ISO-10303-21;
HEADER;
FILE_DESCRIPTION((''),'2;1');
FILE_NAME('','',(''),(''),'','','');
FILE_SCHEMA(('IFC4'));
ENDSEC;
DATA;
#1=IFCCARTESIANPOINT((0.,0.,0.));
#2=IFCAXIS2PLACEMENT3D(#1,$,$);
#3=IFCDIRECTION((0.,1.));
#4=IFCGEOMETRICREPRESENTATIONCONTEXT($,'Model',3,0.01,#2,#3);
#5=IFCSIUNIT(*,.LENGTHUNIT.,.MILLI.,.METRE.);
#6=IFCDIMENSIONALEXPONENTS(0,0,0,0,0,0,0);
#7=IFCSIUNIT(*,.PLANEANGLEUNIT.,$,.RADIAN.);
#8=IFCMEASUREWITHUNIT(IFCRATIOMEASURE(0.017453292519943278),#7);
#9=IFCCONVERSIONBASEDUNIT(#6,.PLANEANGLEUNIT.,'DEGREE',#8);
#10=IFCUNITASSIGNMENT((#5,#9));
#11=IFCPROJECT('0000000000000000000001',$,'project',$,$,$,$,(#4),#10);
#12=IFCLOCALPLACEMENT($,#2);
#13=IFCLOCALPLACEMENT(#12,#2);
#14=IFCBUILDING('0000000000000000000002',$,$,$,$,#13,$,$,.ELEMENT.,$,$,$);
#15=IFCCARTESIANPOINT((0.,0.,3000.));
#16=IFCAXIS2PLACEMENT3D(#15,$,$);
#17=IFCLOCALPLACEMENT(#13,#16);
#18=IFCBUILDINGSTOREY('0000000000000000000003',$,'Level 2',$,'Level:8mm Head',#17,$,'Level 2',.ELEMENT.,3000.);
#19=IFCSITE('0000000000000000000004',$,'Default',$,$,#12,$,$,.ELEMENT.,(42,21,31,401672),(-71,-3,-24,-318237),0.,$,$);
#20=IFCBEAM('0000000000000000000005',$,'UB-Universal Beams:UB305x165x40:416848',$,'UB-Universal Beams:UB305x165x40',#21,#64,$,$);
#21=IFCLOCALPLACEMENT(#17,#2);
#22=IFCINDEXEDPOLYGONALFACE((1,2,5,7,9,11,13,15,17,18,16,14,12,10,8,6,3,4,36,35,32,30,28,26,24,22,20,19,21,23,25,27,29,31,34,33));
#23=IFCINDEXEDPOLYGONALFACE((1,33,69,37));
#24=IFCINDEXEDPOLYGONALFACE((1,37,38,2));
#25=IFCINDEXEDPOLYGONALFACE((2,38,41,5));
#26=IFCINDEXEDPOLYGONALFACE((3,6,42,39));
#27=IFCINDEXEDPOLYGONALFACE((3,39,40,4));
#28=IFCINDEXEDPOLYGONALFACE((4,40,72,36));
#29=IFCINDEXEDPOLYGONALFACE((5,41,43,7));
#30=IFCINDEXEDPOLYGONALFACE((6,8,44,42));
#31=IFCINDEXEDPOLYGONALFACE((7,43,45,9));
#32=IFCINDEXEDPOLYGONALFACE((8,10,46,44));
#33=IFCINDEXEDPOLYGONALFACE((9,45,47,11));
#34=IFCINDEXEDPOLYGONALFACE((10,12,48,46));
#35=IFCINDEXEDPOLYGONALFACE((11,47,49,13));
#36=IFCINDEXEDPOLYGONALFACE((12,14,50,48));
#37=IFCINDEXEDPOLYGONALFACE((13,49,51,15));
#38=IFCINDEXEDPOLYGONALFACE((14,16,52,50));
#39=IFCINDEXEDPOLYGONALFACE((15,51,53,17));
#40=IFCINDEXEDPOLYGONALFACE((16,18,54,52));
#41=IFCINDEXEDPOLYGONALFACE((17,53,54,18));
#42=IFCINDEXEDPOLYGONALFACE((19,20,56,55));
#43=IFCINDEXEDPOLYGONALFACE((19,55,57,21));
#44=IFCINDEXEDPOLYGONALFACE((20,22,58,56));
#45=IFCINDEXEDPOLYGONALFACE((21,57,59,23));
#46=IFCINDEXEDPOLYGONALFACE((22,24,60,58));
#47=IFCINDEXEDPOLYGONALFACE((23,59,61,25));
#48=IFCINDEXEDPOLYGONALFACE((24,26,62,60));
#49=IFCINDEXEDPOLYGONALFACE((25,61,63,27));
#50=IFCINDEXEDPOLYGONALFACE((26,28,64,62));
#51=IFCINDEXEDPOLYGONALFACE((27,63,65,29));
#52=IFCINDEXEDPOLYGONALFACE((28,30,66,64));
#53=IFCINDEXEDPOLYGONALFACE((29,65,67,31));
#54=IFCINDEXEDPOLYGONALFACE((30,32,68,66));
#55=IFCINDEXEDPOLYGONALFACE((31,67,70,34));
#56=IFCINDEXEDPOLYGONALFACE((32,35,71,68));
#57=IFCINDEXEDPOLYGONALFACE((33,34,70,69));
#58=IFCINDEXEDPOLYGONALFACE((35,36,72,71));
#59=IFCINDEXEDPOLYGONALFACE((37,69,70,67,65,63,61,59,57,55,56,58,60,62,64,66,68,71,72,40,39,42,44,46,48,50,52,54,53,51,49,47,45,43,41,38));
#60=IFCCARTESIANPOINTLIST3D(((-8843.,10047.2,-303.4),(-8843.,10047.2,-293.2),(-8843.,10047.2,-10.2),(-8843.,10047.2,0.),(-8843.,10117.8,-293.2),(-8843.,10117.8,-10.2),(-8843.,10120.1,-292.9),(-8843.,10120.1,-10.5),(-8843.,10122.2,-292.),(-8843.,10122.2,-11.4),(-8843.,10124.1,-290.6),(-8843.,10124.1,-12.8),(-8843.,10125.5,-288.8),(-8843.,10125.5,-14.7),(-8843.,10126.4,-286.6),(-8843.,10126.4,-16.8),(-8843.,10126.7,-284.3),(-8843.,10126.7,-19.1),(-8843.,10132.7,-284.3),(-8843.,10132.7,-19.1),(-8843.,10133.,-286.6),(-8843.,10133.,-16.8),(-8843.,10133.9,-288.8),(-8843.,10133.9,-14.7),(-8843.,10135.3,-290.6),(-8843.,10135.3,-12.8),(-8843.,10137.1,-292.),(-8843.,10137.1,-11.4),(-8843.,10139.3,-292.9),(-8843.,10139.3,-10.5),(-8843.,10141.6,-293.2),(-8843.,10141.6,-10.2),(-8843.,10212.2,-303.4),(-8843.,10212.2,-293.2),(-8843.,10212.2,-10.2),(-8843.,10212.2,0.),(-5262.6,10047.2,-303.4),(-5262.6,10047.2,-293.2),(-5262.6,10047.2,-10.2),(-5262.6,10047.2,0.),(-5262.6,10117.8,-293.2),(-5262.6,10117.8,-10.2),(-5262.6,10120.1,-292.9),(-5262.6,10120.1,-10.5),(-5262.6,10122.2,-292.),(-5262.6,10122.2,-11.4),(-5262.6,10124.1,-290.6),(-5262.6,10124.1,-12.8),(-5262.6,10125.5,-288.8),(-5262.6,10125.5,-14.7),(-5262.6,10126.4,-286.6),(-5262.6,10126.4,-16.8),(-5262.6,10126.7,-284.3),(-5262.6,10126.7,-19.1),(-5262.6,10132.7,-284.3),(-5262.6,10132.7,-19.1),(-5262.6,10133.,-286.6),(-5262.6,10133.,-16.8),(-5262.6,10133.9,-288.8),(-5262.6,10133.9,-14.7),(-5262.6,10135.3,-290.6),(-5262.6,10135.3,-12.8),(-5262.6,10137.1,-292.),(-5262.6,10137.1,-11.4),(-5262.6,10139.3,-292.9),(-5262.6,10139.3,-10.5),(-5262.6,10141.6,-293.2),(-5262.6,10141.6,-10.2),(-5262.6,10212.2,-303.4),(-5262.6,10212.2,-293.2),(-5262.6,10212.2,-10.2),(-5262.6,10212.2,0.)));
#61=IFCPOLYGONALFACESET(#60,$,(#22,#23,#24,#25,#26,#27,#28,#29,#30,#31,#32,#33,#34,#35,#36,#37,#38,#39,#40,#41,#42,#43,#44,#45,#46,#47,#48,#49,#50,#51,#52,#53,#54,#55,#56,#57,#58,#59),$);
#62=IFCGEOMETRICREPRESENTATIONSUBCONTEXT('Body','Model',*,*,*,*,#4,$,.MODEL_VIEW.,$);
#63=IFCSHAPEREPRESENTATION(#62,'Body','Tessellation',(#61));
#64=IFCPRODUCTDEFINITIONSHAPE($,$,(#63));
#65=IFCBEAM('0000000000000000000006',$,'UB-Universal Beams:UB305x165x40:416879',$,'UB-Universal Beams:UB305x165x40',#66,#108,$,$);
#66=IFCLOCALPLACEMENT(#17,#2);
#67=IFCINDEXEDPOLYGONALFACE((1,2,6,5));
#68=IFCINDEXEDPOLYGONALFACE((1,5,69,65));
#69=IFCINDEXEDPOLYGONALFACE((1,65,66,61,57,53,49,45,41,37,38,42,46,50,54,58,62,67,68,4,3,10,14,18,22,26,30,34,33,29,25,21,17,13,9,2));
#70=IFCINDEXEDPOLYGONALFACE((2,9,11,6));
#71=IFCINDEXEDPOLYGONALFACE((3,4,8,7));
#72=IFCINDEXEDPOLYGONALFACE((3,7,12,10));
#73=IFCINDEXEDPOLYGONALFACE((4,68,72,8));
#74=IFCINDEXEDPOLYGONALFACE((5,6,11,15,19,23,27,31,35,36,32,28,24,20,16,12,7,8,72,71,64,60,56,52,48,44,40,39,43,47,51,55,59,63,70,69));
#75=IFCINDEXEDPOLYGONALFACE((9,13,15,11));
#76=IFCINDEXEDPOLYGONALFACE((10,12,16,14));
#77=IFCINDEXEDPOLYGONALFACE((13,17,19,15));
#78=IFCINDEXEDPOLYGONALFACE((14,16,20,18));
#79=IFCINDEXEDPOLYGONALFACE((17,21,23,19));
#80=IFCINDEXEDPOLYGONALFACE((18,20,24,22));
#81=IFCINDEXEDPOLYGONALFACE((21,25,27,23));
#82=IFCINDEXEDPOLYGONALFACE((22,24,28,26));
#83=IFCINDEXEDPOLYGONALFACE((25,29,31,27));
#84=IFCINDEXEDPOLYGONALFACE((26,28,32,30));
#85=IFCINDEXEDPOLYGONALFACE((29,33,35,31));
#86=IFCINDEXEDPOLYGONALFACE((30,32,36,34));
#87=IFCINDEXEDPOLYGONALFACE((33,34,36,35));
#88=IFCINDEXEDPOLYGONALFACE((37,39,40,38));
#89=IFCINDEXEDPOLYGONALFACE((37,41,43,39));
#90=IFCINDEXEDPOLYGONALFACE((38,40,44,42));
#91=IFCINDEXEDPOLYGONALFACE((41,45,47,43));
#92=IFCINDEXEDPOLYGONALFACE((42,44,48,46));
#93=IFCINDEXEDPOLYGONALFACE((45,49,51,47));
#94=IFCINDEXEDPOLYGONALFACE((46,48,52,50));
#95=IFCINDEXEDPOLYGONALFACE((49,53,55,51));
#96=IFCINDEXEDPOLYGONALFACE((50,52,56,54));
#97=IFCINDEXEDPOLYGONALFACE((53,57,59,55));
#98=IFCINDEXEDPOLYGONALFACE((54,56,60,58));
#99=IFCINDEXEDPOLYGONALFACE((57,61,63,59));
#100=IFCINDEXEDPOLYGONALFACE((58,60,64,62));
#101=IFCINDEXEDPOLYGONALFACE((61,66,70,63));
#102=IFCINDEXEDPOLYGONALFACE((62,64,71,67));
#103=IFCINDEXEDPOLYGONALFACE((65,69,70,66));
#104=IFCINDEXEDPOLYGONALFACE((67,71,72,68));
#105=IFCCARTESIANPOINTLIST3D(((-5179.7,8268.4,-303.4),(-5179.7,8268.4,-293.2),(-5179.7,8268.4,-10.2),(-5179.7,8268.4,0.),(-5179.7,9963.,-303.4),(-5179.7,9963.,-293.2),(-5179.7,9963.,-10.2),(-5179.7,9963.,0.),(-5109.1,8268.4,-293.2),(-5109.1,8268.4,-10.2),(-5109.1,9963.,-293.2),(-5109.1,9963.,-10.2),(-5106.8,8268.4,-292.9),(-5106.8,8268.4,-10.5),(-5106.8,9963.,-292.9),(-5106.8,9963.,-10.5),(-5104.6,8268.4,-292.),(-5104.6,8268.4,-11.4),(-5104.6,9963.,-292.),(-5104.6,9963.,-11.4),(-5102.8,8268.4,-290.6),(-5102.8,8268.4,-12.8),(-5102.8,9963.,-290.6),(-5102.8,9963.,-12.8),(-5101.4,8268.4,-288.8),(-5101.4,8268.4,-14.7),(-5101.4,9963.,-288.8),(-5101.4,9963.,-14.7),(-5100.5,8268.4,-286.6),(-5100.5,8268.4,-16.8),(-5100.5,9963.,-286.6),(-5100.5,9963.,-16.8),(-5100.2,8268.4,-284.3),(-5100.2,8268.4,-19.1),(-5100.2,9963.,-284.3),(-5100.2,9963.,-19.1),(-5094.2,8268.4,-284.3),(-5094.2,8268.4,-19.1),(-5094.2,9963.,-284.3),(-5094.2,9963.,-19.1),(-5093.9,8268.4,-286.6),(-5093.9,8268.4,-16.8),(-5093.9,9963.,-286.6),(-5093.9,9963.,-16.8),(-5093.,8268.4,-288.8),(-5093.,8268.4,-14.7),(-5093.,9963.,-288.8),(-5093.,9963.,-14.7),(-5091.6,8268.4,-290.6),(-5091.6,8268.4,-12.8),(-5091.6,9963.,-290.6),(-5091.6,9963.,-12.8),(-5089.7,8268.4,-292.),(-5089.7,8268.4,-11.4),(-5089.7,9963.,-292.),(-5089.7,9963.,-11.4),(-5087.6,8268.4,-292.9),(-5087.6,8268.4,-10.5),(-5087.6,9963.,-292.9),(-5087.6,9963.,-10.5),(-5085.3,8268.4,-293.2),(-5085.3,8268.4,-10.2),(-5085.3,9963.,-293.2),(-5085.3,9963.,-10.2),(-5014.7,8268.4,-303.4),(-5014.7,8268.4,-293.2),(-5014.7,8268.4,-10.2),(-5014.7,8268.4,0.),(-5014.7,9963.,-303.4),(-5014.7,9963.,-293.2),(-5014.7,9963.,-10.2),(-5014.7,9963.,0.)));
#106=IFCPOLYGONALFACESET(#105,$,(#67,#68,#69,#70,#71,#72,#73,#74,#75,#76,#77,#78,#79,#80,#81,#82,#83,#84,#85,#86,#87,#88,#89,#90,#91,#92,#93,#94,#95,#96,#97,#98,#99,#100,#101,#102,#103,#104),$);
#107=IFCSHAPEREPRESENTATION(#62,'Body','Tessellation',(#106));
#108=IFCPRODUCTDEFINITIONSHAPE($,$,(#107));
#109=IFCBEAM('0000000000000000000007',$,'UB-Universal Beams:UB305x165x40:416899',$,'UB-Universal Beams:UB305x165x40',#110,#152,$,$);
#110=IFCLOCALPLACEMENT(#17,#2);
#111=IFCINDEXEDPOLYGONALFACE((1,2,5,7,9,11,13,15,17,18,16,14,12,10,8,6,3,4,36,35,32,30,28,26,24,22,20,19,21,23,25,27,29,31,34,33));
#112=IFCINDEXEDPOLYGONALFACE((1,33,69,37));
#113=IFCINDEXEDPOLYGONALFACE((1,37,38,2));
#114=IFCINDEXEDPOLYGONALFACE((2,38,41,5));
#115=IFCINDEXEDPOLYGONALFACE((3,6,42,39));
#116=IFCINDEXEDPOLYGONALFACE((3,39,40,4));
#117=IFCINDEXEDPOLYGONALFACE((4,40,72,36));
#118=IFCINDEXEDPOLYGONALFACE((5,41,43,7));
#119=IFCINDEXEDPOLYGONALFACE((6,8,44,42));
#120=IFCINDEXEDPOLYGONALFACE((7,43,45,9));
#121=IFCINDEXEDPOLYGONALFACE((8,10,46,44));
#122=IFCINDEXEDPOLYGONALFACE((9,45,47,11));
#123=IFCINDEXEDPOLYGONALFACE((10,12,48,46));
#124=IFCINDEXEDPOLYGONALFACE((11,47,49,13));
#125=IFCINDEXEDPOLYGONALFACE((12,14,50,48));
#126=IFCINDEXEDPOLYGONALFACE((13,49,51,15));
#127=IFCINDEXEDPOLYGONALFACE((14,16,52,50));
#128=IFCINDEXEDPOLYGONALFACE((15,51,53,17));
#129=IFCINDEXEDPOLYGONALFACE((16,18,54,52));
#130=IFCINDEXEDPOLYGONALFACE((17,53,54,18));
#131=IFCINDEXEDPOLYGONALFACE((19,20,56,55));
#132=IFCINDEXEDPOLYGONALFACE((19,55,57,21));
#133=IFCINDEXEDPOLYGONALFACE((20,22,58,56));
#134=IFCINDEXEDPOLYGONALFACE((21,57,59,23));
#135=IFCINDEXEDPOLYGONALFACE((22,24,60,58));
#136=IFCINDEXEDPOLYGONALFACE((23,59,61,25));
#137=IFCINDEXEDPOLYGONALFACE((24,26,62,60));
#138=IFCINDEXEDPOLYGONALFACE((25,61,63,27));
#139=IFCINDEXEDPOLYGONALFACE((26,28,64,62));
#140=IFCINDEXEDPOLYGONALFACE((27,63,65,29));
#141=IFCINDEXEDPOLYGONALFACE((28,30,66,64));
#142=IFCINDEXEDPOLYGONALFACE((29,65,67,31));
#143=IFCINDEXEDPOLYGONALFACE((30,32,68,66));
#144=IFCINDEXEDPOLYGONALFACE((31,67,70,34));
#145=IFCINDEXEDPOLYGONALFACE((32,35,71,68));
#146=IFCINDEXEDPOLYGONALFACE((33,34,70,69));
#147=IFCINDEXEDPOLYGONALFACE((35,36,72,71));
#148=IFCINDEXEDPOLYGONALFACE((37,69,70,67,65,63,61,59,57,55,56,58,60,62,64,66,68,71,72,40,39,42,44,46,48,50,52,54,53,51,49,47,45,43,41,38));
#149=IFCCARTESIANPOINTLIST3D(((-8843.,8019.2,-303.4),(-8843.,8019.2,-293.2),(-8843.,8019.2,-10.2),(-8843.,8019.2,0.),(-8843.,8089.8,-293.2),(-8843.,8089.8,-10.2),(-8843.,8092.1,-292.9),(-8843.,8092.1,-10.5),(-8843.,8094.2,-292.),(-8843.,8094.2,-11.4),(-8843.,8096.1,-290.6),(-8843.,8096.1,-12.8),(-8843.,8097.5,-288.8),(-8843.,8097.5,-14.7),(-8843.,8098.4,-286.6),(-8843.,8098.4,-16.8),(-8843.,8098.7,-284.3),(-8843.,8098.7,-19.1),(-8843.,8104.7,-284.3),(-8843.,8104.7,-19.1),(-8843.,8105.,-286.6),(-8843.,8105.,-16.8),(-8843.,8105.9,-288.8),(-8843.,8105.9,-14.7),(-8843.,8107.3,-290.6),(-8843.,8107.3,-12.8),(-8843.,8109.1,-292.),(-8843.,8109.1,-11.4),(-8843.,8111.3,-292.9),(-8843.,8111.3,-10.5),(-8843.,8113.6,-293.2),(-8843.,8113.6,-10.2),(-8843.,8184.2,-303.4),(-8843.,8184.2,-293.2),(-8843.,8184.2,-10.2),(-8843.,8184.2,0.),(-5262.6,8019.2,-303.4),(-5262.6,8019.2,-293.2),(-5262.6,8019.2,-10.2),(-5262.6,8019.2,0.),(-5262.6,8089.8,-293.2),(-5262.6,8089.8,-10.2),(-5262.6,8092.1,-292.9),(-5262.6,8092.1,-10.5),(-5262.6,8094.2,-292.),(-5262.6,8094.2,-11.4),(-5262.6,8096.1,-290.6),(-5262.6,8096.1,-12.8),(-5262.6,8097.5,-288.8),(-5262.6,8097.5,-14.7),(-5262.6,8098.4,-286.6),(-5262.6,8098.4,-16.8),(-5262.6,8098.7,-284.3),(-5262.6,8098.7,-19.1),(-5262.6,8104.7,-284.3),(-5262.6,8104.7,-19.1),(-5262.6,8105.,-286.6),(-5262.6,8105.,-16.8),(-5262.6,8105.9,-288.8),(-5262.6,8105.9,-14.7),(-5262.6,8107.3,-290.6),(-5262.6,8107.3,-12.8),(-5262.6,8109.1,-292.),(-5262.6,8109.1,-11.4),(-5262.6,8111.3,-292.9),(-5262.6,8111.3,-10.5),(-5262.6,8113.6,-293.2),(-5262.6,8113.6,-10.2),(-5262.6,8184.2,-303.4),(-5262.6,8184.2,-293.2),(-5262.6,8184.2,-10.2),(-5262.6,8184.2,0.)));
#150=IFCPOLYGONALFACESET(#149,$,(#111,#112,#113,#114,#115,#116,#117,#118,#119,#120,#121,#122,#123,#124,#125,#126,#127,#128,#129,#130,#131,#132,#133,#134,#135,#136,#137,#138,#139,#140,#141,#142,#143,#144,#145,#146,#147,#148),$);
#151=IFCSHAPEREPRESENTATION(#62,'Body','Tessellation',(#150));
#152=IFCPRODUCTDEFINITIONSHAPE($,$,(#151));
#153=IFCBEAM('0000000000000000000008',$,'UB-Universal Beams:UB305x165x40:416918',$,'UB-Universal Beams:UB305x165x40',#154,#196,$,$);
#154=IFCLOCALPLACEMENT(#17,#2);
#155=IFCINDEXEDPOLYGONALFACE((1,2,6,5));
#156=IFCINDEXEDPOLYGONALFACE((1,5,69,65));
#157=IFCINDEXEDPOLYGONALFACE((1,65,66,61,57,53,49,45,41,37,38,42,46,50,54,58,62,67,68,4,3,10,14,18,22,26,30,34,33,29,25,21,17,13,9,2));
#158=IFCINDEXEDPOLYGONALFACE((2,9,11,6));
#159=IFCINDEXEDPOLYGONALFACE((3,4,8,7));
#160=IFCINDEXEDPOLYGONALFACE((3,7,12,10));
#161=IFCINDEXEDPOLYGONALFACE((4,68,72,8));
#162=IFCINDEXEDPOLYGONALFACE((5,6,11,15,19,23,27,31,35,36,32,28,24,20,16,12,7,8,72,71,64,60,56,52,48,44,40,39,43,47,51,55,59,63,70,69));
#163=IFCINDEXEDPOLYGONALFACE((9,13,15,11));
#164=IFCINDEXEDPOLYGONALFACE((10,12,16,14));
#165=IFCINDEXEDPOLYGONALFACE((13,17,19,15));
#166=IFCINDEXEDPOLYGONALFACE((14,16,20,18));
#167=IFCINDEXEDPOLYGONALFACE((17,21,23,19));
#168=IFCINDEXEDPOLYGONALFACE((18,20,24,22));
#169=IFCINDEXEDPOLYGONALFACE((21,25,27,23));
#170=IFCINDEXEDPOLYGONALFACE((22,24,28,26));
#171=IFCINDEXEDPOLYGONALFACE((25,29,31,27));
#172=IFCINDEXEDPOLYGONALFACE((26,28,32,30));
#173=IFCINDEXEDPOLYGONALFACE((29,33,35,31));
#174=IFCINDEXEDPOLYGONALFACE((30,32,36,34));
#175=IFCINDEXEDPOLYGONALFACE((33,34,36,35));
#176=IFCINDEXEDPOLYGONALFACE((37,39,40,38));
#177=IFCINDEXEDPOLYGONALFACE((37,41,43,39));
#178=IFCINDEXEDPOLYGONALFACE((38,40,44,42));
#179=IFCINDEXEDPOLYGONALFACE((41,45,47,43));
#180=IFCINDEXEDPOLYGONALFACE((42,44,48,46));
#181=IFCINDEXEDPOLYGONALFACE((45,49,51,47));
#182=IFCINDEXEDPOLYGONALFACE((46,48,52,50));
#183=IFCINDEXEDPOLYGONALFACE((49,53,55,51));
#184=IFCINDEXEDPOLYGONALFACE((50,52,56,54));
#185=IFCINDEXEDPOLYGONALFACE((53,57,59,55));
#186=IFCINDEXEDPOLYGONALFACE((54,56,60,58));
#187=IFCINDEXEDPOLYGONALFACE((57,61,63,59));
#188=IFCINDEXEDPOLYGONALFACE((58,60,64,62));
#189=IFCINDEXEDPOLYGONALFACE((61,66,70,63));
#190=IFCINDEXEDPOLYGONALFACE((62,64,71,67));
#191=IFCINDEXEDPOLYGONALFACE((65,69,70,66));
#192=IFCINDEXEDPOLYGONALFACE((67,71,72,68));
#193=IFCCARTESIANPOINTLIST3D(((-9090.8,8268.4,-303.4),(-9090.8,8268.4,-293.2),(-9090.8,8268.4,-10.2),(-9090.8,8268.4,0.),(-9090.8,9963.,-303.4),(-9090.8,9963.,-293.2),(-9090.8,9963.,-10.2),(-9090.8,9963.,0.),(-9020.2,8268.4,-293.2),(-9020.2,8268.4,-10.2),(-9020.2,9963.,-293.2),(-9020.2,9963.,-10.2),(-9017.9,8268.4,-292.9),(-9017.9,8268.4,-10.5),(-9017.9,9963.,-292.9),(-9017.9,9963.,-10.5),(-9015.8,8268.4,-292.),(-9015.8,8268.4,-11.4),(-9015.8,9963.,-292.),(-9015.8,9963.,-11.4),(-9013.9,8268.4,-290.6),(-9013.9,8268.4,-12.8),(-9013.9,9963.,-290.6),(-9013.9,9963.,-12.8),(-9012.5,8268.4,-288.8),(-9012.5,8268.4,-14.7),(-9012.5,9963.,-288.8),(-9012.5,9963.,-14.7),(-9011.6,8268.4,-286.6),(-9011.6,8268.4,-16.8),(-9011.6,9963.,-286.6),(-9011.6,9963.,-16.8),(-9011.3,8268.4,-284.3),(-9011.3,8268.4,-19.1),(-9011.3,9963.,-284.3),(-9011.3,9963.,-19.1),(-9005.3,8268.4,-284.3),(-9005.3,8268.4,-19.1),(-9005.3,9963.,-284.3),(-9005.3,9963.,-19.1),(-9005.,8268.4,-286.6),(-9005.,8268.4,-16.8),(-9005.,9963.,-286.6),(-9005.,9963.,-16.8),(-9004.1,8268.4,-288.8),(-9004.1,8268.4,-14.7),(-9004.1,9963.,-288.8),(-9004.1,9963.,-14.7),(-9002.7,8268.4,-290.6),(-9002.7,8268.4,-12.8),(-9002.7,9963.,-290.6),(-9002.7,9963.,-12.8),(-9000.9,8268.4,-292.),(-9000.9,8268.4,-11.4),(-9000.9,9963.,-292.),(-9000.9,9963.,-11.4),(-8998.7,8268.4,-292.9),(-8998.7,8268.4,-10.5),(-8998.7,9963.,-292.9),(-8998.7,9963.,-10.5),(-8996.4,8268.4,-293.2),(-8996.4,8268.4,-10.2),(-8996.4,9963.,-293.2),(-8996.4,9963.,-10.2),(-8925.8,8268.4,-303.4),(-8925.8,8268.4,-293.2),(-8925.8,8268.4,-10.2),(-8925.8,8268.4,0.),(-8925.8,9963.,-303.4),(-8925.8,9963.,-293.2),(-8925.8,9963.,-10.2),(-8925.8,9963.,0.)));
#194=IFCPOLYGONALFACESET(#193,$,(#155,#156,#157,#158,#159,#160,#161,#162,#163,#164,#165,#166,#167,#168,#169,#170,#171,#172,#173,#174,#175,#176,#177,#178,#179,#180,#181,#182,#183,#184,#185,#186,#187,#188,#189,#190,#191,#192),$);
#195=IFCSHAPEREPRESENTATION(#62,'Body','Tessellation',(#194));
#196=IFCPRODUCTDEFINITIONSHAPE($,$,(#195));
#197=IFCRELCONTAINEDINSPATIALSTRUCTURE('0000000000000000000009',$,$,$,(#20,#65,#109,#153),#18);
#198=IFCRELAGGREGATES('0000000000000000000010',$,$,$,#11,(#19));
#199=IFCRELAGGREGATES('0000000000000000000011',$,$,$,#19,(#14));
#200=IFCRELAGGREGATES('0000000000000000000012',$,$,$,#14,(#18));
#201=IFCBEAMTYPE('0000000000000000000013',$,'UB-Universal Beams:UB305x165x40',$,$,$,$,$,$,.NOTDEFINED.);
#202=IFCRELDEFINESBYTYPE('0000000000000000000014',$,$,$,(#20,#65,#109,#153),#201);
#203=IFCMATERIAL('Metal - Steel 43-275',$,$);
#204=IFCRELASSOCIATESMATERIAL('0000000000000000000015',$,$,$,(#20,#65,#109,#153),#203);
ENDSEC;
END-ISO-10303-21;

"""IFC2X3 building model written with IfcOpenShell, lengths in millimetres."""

from ifc_helpers import new_model, entity, si_unit, converted_unit, direction, frame, frame_2d, origin, place, context, subcontext, project, spatial, i_section, extrude, material, type_object, element, save


model = new_model("IFC2X3")

# Units and contexts
model_context = context("Model", 3, precision=0.01, world=origin(), true_north=direction((0.0, 1.0)))
body_context = subcontext(model_context, "Body", "Model", "MODEL_VIEW")
ifc_project = project(units=[si_unit("LENGTHUNIT", "METRE", prefix="MILLI"), converted_unit("PLANEANGLEUNIT", "DEGREE", entity("IfcRatioMeasure", 0.017453292519943278), si_unit("PLANEANGLEUNIT", "RADIAN"), dimensions=[0, 0, 0, 0, 0, 0, 0])], contexts=[model_context])

# Site, building, storey
site_placement = place(None, origin())
site = spatial("IfcSite", under=ifc_project, at=site_placement, Name="Default", CompositionType="ELEMENT", RefLatitude=(42, 21, 31, 401672), RefLongitude=(-71, -3, -24, -318237), RefElevation=0.0)
building_placement = place(site_placement, origin())
building = spatial("IfcBuilding", under=site, at=building_placement, CompositionType="ELEMENT")
storey_placement = place(building_placement, frame((0.0, 0.0, 3000.0)))
storey = spatial("IfcBuildingStorey", under=building, at=storey_placement, Name="Level 2", ObjectType="Level:8mm Head", LongName="Level 2", CompositionType="ELEMENT", Elevation=3000.0)

# Beams
ifc_material_1 = material(Name="Metal - Steel 43-275")
beam_type = type_object("IfcBeamType", Name="UB-Universal Beams:UB305x165x40", PredefinedType="NOTDEFINED")
beam_1_placement = place(storey_placement, frame((-9008.3, 10129.7, 0.0)))
element("IfcBeam", 1, at=beam_1_placement, inside=storey, type_object=beam_type, material=ifc_material_1, Name="UB-Universal Beams:UB305x165x40:416848", ObjectType="UB-Universal Beams:UB305x165x40", context=body_context, shape_type="SweptSolid", body=[
    extrude(i_section(OverallWidth=165.0, OverallDepth=303.4, WebThickness=6.0, FlangeThickness=10.2, FilletRadius=8.9, at=frame_2d((0.0, 0.0), x_axis=(0.0, 1.0))), frame((165.4, 0.0, -151.7), z_axis=(1.0, 0.0, 0.0), x_axis=(0.0, 0.0, -1.0)), (0.0, 0.0, 1.0), 3580.4),
])
beam_2_placement = place(storey_placement, frame((-5097.2, 10129.7, 0.0), z_axis=(0.0, 0.0, 1.0), x_axis=(0.0, -1.0, 0.0)))
element("IfcBeam", 2, at=beam_2_placement, inside=storey, type_object=beam_type, material=ifc_material_1, Name="UB-Universal Beams:UB305x165x40:416879", ObjectType="UB-Universal Beams:UB305x165x40", context=body_context, shape_type="SweptSolid", body=[
    extrude(i_section(OverallWidth=165.0, OverallDepth=303.4, WebThickness=6.0, FlangeThickness=10.2, FilletRadius=8.9, at=frame_2d((0.0, 0.0), x_axis=(0.0, 1.0))), frame((166.7, 0.0, -151.7), z_axis=(1.0, 0.0, 0.0), x_axis=(0.0, 0.0, -1.0)), (0.0, 0.0, 1.0), 1694.6),
])
beam_3_placement = place(storey_placement, frame((-5097.2, 8101.7, 0.0), z_axis=(0.0, 0.0, 1.0), x_axis=(-1.0, 0.0, 0.0)))
element("IfcBeam", 3, at=beam_3_placement, inside=storey, type_object=beam_type, material=ifc_material_1, Name="UB-Universal Beams:UB305x165x40:416899", ObjectType="UB-Universal Beams:UB305x165x40", context=body_context, shape_type="SweptSolid", body=[
    extrude(i_section(OverallWidth=165.0, OverallDepth=303.4, WebThickness=6.0, FlangeThickness=10.2, FilletRadius=8.9, at=frame_2d((0.0, 0.0), x_axis=(0.0, 1.0))), frame((165.4, 0.0, -151.7), z_axis=(1.0, 0.0, 0.0), x_axis=(0.0, 0.0, -1.0)), (0.0, 0.0, 1.0), 3580.4),
])
beam_4_placement = place(storey_placement, frame((-9008.3, 8101.7, 0.0), z_axis=(0.0, 0.0, 1.0), x_axis=(0.0, 1.0, 0.0)))
element("IfcBeam", 4, at=beam_4_placement, inside=storey, type_object=beam_type, material=ifc_material_1, Name="UB-Universal Beams:UB305x165x40:416918", ObjectType="UB-Universal Beams:UB305x165x40", context=body_context, shape_type="SweptSolid", body=[
    extrude(i_section(OverallWidth=165.0, OverallDepth=303.4, WebThickness=6.0, FlangeThickness=10.2, FilletRadius=8.9, at=frame_2d((0.0, 0.0), x_axis=(0.0, 1.0))), frame((166.7, 0.0, -151.7), z_axis=(1.0, 0.0, 0.0), x_axis=(0.0, 0.0, -1.0)), (0.0, 0.0, 1.0), 1694.6),
])

save(model, "model.ifc")
